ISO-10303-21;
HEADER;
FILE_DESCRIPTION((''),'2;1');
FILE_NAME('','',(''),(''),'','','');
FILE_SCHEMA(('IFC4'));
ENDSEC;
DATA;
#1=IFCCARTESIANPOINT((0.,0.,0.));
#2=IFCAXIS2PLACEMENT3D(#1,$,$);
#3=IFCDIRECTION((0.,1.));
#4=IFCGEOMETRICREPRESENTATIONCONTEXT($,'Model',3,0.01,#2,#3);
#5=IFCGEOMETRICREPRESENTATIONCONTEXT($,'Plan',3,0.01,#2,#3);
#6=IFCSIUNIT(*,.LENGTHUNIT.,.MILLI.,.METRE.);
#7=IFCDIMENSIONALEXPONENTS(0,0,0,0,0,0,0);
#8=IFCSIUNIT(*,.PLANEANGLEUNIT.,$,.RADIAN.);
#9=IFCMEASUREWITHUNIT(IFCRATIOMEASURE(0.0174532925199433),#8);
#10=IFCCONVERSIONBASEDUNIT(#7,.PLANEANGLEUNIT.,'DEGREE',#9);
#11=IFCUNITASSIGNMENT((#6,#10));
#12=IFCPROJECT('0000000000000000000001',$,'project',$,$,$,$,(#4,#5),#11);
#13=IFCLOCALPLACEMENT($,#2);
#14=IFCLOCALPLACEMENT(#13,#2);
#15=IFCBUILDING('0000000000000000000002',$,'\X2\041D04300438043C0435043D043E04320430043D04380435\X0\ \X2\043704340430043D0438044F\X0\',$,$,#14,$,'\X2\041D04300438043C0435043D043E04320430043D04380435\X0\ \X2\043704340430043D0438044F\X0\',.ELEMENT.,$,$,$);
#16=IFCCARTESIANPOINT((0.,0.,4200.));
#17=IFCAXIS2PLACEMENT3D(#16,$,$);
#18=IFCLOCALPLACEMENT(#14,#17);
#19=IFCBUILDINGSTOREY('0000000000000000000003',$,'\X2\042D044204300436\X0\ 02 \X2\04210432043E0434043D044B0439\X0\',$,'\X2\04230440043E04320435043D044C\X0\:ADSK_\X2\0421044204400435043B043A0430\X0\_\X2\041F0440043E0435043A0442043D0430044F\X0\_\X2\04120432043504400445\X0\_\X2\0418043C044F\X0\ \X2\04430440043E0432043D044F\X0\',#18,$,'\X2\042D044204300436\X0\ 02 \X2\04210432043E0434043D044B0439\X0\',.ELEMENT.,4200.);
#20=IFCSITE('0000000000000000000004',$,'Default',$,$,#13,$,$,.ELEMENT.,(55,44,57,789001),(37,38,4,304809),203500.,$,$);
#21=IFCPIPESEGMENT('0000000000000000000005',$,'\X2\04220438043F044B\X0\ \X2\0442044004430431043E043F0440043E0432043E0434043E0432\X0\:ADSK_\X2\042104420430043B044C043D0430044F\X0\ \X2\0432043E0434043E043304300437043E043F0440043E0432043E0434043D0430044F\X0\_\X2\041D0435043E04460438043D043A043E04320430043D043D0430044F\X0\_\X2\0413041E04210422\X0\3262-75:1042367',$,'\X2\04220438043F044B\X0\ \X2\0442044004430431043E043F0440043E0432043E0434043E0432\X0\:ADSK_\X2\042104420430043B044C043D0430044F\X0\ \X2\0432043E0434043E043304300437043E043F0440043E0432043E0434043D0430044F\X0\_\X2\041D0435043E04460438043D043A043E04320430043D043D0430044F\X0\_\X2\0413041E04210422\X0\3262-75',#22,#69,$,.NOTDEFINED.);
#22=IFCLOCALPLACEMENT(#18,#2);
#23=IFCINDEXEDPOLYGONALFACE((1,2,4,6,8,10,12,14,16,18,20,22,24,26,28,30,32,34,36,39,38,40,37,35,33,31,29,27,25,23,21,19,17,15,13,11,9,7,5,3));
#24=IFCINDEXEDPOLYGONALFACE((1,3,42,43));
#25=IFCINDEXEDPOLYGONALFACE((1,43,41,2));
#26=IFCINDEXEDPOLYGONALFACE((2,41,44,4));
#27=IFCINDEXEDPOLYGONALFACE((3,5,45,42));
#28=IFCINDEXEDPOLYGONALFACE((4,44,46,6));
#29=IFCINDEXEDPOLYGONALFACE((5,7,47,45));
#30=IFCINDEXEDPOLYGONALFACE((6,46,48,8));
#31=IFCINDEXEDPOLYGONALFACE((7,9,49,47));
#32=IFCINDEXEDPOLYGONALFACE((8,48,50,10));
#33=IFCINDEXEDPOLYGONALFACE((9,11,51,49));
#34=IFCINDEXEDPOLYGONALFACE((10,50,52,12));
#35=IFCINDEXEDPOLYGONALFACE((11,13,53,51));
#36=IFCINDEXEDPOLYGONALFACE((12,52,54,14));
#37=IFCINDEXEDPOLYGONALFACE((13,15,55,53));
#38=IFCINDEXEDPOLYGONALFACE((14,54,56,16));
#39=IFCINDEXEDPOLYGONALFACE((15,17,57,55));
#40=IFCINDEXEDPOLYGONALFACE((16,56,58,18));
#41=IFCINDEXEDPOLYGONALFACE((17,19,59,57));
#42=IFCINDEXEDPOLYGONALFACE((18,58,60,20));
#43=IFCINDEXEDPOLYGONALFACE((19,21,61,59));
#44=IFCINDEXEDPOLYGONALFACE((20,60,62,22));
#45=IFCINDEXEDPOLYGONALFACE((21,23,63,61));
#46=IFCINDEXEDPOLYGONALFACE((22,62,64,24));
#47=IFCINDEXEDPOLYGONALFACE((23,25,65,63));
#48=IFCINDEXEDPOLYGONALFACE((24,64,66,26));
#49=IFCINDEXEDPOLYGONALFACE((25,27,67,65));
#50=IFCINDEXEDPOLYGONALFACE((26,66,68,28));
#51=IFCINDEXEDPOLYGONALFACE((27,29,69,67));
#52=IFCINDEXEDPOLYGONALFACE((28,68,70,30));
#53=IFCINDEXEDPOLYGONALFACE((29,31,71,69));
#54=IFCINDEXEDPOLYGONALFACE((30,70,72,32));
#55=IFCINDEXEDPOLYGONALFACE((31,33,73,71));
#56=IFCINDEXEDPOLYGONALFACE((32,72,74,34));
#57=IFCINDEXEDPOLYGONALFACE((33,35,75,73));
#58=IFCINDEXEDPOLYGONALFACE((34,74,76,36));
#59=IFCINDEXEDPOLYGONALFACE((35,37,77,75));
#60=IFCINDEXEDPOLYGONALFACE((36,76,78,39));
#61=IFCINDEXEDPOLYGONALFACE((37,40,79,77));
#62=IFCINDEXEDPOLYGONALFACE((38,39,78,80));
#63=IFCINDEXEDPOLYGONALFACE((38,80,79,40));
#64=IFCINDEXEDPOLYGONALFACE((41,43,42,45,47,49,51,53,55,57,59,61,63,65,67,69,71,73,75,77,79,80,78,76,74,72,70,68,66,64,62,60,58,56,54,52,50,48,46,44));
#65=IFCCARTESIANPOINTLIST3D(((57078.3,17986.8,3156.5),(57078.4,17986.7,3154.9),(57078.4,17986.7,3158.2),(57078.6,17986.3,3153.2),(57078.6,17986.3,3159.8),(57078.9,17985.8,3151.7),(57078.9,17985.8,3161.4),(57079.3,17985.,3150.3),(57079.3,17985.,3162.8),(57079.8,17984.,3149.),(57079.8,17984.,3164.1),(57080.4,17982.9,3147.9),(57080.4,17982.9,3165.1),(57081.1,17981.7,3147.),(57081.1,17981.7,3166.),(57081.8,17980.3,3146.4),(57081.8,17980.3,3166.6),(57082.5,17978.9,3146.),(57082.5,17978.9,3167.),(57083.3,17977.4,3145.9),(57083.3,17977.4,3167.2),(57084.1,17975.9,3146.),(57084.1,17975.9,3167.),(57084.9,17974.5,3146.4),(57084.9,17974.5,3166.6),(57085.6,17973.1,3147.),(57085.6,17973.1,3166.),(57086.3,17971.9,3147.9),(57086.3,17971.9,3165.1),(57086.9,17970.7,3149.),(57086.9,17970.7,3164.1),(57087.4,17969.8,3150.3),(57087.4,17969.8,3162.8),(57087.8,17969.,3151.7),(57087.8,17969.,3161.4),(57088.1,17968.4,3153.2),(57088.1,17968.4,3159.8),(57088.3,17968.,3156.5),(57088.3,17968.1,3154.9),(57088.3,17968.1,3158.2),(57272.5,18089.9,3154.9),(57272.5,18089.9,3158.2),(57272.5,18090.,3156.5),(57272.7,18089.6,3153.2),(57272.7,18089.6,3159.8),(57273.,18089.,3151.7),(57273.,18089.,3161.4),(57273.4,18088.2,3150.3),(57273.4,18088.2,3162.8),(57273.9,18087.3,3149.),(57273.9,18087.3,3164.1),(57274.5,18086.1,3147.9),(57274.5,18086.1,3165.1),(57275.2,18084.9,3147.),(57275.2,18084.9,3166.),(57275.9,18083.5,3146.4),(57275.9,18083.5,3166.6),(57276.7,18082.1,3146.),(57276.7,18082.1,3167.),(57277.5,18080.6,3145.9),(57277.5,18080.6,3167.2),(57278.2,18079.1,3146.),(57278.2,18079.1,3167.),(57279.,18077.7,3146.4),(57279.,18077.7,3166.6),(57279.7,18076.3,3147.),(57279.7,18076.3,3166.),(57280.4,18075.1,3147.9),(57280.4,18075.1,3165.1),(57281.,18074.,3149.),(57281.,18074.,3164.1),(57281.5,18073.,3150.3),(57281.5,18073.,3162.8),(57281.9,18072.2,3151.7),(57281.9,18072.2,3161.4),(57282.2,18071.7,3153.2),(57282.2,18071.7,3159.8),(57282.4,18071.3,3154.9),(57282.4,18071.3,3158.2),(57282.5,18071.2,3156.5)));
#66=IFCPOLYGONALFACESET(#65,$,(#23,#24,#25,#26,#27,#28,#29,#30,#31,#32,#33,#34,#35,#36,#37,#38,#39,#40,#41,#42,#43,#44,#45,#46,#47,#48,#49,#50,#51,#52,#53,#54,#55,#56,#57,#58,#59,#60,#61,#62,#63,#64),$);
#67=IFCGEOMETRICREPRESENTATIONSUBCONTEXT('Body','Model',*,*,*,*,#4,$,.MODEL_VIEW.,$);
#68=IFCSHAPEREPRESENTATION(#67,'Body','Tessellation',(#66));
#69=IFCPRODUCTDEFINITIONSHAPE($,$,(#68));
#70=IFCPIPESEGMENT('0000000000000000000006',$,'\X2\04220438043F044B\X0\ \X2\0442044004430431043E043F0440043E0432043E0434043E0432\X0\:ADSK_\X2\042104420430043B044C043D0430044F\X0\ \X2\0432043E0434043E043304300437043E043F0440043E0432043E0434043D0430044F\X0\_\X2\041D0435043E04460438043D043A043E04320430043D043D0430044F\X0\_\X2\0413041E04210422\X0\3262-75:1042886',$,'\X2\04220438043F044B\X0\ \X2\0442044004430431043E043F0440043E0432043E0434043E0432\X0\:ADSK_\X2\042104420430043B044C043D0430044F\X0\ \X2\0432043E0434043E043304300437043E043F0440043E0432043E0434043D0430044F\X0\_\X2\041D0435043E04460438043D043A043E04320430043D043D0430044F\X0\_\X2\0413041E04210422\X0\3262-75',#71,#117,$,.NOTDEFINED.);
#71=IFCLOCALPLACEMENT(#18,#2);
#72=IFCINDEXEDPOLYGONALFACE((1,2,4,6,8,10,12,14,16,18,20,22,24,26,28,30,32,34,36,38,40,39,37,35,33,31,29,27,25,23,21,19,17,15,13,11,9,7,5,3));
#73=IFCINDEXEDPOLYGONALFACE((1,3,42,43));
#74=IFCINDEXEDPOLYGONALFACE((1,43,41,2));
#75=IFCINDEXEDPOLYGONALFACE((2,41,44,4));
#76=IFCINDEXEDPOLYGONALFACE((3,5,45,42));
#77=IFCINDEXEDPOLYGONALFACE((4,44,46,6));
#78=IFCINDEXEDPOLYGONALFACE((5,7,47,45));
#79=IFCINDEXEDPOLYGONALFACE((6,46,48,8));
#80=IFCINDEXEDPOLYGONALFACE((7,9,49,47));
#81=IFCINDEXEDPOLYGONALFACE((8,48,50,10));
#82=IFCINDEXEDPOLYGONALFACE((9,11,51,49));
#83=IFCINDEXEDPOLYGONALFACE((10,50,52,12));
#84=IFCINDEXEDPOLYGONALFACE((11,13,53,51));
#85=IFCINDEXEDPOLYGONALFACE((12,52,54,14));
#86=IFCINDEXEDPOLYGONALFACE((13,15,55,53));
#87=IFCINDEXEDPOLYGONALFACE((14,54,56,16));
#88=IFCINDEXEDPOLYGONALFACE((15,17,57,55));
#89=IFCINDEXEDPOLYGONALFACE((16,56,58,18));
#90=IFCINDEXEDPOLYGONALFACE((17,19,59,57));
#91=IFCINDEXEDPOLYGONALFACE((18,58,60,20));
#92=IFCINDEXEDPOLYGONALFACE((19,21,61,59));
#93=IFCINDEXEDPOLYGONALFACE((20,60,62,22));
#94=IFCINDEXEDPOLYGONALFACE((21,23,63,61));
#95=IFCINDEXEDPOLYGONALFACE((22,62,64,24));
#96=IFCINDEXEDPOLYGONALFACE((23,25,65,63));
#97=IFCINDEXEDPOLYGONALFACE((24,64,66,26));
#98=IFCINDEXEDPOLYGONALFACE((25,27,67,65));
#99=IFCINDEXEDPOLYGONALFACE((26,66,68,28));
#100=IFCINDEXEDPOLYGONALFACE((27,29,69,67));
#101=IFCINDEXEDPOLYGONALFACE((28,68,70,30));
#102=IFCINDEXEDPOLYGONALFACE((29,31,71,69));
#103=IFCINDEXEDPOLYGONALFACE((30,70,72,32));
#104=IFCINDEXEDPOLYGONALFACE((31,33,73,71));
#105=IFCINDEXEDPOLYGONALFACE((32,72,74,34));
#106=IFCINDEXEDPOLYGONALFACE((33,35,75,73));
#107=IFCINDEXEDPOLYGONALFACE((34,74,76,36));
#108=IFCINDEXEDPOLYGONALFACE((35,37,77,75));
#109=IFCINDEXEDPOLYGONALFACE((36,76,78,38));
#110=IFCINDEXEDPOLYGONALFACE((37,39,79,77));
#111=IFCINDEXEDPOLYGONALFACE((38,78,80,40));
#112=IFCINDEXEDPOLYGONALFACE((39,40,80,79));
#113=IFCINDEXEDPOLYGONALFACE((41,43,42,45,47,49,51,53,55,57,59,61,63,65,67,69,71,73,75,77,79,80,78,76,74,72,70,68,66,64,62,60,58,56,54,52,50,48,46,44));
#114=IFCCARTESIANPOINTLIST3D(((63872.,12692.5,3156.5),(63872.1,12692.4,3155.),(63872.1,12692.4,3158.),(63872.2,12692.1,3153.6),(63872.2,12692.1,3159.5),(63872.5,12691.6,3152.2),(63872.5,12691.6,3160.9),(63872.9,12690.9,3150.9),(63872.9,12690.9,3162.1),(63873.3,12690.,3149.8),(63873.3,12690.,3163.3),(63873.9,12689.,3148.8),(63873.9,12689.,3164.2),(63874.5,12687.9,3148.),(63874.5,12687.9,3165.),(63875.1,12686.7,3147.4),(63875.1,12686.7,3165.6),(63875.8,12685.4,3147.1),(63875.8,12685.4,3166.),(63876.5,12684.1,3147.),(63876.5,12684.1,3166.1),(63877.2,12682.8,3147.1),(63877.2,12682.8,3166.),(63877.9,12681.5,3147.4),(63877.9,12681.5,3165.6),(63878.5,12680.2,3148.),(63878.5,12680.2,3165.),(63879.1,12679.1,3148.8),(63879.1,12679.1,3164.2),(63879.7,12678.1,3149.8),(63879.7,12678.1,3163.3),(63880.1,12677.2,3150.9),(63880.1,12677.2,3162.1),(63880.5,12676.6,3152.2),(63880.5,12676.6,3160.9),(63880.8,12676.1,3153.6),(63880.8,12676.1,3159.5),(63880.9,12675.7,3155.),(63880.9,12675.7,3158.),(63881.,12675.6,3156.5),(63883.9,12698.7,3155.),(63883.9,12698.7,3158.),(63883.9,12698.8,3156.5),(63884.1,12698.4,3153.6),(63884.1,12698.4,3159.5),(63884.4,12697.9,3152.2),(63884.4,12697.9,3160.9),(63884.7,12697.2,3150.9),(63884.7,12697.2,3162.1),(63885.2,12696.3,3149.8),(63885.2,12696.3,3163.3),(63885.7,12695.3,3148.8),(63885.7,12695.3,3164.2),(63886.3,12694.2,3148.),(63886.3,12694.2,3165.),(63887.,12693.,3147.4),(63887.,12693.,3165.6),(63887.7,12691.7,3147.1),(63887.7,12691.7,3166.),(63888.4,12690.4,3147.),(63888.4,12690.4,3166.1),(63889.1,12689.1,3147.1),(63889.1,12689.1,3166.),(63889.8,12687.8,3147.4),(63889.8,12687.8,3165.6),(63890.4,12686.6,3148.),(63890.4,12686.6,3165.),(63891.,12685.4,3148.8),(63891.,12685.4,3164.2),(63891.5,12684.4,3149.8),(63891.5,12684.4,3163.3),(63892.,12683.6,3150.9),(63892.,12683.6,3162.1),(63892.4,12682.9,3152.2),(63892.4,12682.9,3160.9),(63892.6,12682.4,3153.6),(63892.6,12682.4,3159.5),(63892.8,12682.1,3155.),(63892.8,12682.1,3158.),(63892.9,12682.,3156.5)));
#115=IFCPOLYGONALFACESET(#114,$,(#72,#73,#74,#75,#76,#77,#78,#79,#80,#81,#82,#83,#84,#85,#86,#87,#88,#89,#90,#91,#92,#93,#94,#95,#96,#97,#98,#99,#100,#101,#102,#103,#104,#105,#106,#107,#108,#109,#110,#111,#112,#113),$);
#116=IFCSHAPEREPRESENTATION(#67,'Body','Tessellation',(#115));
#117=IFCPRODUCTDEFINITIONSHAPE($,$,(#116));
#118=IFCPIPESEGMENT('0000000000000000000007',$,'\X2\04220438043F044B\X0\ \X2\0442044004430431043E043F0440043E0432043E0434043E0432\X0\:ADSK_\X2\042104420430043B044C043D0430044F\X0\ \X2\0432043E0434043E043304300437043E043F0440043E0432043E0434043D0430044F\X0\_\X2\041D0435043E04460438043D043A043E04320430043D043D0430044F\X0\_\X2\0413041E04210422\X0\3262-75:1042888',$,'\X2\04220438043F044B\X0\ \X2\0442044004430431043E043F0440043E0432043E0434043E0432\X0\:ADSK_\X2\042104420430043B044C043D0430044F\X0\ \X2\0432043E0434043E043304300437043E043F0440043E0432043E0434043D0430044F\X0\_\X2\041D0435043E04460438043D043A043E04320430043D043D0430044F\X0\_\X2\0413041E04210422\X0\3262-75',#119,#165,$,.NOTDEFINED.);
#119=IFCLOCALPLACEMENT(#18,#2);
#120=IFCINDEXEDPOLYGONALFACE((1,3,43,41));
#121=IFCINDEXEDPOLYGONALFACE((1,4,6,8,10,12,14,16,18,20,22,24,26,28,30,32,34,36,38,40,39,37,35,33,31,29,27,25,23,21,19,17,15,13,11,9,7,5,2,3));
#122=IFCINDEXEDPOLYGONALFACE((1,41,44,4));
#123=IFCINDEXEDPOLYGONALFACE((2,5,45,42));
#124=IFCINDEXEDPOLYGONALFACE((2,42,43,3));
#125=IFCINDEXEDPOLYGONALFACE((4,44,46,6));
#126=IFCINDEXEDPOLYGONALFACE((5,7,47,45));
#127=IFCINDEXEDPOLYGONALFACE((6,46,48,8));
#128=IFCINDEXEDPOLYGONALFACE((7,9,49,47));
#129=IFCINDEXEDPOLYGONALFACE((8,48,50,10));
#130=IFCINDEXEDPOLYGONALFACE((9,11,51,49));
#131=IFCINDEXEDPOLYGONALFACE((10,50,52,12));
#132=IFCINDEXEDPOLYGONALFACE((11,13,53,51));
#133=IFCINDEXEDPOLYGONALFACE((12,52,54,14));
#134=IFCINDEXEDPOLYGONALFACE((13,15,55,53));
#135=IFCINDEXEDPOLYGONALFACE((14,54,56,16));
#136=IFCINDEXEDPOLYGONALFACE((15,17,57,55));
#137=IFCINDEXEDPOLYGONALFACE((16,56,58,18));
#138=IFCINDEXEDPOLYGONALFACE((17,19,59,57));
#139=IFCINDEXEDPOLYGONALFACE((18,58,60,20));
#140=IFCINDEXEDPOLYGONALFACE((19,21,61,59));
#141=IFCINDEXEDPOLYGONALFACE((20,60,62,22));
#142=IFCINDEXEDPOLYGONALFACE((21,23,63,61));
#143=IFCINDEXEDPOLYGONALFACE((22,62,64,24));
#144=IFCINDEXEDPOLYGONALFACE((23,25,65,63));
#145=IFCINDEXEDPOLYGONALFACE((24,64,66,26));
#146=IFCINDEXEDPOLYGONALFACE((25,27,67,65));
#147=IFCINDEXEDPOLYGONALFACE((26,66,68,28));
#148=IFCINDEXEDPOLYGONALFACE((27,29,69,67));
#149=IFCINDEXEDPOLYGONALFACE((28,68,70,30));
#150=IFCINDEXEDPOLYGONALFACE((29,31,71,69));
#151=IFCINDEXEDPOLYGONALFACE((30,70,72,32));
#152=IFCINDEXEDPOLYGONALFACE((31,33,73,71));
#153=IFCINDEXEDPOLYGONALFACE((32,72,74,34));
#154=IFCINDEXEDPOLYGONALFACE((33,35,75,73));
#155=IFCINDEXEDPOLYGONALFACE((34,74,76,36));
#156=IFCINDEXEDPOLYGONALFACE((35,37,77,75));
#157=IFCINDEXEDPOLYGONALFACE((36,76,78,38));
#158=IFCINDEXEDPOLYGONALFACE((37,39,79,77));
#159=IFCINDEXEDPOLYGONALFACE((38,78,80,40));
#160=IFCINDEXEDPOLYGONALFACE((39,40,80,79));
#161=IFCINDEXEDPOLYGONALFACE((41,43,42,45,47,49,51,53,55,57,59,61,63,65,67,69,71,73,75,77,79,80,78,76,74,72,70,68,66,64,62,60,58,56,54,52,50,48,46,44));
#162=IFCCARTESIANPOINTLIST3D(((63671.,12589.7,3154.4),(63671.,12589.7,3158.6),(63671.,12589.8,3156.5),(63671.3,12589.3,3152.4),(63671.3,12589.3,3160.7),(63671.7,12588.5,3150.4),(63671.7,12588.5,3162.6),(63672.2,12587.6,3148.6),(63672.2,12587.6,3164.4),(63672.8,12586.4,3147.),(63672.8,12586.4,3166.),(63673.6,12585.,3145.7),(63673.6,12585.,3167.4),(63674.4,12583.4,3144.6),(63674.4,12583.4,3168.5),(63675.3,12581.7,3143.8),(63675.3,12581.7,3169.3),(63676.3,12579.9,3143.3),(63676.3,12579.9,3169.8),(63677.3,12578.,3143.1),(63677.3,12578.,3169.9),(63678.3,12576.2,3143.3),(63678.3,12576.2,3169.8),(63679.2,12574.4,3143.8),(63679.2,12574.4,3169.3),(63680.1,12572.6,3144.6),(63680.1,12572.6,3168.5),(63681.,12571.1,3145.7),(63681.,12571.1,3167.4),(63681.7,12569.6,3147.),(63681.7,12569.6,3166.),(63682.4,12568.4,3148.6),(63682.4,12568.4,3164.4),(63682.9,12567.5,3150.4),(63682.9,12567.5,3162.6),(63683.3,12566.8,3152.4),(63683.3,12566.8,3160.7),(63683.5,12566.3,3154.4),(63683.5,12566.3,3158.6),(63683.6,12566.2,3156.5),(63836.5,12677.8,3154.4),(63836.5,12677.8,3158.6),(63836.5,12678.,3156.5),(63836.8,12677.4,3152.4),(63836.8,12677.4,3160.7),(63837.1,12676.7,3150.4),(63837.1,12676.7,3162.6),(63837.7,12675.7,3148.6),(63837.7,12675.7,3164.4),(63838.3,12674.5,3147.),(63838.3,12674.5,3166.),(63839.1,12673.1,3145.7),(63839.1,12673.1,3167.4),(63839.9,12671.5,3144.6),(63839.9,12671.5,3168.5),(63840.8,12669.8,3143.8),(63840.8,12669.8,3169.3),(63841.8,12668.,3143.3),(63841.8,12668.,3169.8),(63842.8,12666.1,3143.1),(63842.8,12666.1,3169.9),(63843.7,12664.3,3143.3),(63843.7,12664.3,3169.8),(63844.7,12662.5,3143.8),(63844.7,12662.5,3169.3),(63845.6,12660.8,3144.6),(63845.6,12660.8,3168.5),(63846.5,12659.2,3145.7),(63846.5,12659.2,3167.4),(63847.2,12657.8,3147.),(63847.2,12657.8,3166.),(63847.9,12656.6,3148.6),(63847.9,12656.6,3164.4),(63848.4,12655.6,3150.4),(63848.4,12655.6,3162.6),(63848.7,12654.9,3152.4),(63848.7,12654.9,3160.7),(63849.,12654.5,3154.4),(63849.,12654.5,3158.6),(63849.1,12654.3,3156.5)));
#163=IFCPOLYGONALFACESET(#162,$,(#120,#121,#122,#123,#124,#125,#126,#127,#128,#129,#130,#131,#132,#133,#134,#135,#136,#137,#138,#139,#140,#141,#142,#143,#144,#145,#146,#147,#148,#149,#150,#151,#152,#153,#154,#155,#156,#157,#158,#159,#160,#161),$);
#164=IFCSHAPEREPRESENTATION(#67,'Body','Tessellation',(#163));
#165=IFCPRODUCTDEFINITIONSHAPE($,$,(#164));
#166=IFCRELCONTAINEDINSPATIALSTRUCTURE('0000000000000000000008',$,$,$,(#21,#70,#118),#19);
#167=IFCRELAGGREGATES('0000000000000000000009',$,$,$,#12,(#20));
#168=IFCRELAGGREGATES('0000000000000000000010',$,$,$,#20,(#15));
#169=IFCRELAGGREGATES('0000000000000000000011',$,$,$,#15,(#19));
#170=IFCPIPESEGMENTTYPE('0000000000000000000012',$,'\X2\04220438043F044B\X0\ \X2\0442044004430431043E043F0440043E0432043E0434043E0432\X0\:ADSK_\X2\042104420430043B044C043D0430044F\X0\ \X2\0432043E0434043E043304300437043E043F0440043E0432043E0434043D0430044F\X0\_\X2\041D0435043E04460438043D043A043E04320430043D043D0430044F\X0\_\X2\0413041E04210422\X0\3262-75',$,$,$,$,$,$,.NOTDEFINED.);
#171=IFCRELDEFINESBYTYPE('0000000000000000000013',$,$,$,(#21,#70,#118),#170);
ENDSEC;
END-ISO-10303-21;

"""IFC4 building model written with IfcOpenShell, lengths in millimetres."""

from ifc_helpers import new_model, entity, si_unit, converted_unit, direction, frame, origin, place, context, subcontext, project, spatial, indexed_curve, outline, extrude, type_object, element, save


model = new_model("IFC4")

# Units and contexts
model_context = context("Model", 3, precision=0.01, world=origin(), true_north=direction((0.0, 1.0)))
plan_context = context("Plan", 3, precision=0.01, world=origin(), true_north=direction((0.0, 1.0)))
body_context = subcontext(model_context, "Body", "Model", "MODEL_VIEW")
ifc_project = project(units=[si_unit("LENGTHUNIT", "METRE", prefix="MILLI"), converted_unit("PLANEANGLEUNIT", "DEGREE", entity("IfcRatioMeasure", 0.0174532925199433), si_unit("PLANEANGLEUNIT", "RADIAN"), dimensions=[0, 0, 0, 0, 0, 0, 0])], contexts=[model_context, plan_context])

# Site, building, storey
site_placement = place(None, origin())
site = spatial("IfcSite", under=ifc_project, at=site_placement, Name="Default", CompositionType="ELEMENT", RefLatitude=(55, 44, 57, 789001), RefLongitude=(37, 38, 4, 304809), RefElevation=203500.0)
building_placement = place(site_placement, origin())
building = spatial("IfcBuilding", under=site, at=building_placement, Name="Наименование здания", LongName="Наименование здания", CompositionType="ELEMENT")
storey_placement = place(building_placement, frame((0.0, 0.0, 4200.0)))
storey = spatial("IfcBuildingStorey", under=building, at=storey_placement, Name="Этаж 02 Сводный", ObjectType="Уровень:ADSK_Стрелка_Проектная_Вверх_Имя уровня", LongName="Этаж 02 Сводный", CompositionType="ELEMENT", Elevation=4200.0)

# Pipe segments
pipe_segment_type = type_object("IfcPipeSegmentType", Name="Типы трубопроводов:ADSK_Стальная водогазопроводная_Неоцинкованная_ГОСТ3262-75", PredefinedType="NOTDEFINED")
placement = place(storey_placement, origin())
element("IfcPipeSegment", 1, at=placement, inside=storey, type_object=pipe_segment_type, Name="Типы трубопроводов:ADSK_Стальная водогазопроводная_Неоцинкованная_ГОСТ3262-75:1042367", ObjectType="Типы трубопроводов:ADSK_Стальная водогазопроводная_Неоцинкованная_ГОСТ3262-75", PredefinedType="NOTDEFINED", context=body_context, shape_type="SweptSolid", body=[
    extrude(outline(indexed_curve([(10.6, 0.0), (10.5, 1.7), (10.1, 3.3), (9.5, 4.8), (8.6, 6.3), (7.5, 7.5), (6.3, 8.6), (4.8, 9.5), (3.3, 10.1), (1.7, 10.5), (0.0, 10.6), (-1.7, 10.5), (-3.3, 10.1), (-4.8, 9.5), (-6.3, 8.6), (-7.5, 7.5), (-8.6, 6.3), (-9.5, 4.8), (-10.1, 3.3), (-10.5, 1.7), (-10.6, 0.0), (-10.5, -1.7), (-10.1, -3.3), (-9.5, -4.8), (-8.6, -6.3), (-7.5, -7.5), (-6.3, -8.6), (-4.8, -9.5), (-3.3, -10.1), (-1.7, -10.5), (0.0, -10.6), (1.7, -10.5), (3.3, -10.1), (4.8, -9.5), (6.3, -8.6), (7.5, -7.5), (8.6, -6.3), (9.5, -4.8), (10.1, -3.3), (10.5, -1.7), (10.6, 0.0)], self_intersect=False)), frame((57083.3, 17977.4, 3156.5), z_axis=(0.882948, 0.469472, 0.0), x_axis=(-0.469472, 0.882948, 0.0)), (0.0, 0.0, 1.0), 219.9),
])
element("IfcPipeSegment", 2, at=placement, inside=storey, type_object=pipe_segment_type, Name="Типы трубопроводов:ADSK_Стальная водогазопроводная_Неоцинкованная_ГОСТ3262-75:1042886", ObjectType="Типы трубопроводов:ADSK_Стальная водогазопроводная_Неоцинкованная_ГОСТ3262-75", PredefinedType="NOTDEFINED", context=body_context, shape_type="SweptSolid", body=[
    extrude(outline(indexed_curve([(9.6, 0.0), (9.4, 1.5), (9.1, 3.0), (8.5, 4.3), (7.7, 5.6), (6.8, 6.8), (5.6, 7.7), (4.3, 8.5), (3.0, 9.1), (1.5, 9.4), (0.0, 9.6), (-1.5, 9.4), (-3.0, 9.1), (-4.3, 8.5), (-5.6, 7.7), (-6.8, 6.8), (-7.7, 5.6), (-8.5, 4.3), (-9.1, 3.0), (-9.4, 1.5), (-9.6, 0.0), (-9.4, -1.5), (-9.1, -3.0), (-8.5, -4.3), (-7.7, -5.6), (-6.8, -6.8), (-5.6, -7.7), (-4.3, -8.5), (-3.0, -9.1), (-1.5, -9.4), (0.0, -9.6), (1.5, -9.4), (3.0, -9.1), (4.3, -8.5), (5.6, -7.7), (6.8, -6.8), (7.7, -5.6), (8.5, -4.3), (9.1, -3.0), (9.4, -1.5), (9.6, 0.0)], self_intersect=False)), frame((63876.5, 12684.1, 3156.5), z_axis=(0.882948, 0.469472, 0.0), x_axis=(-0.469472, 0.882948, 0.0)), (0.0, 0.0, 1.0), 13.5),
])
element("IfcPipeSegment", 3, at=placement, inside=storey, type_object=pipe_segment_type, Name="Типы трубопроводов:ADSK_Стальная водогазопроводная_Неоцинкованная_ГОСТ3262-75:1042888", ObjectType="Типы трубопроводов:ADSK_Стальная водогазопроводная_Неоцинкованная_ГОСТ3262-75", PredefinedType="NOTDEFINED", context=body_context, shape_type="SweptSolid", body=[
    extrude(outline(indexed_curve([(13.4, 0.0), (13.2, 2.1), (12.7, 4.1), (11.9, 6.1), (10.8, 7.9), (9.5, 9.5), (7.9, 10.8), (6.1, 11.9), (4.1, 12.7), (2.1, 13.2), (0.0, 13.4), (-2.1, 13.2), (-4.1, 12.7), (-6.1, 11.9), (-7.9, 10.8), (-9.5, 9.5), (-10.8, 7.9), (-11.9, 6.1), (-12.7, 4.1), (-13.2, 2.1), (-13.4, 0.0), (-13.2, -2.1), (-12.7, -4.1), (-11.9, -6.1), (-10.8, -7.9), (-9.5, -9.5), (-7.9, -10.8), (-6.1, -11.9), (-4.1, -12.7), (-2.1, -13.2), (0.0, -13.4), (2.1, -13.2), (4.1, -12.7), (6.1, -11.9), (7.9, -10.8), (9.5, -9.5), (10.8, -7.9), (11.9, -6.1), (12.7, -4.1), (13.2, -2.1), (13.4, 0.0)], self_intersect=False)), frame((63677.3, 12578.0, 3156.5), z_axis=(0.882652, 0.470027, 0.0), x_axis=(-0.470027, 0.882652, 0.0)), (0.0, 0.0, 1.0), 187.5),
])

save(model, "model.ifc")
